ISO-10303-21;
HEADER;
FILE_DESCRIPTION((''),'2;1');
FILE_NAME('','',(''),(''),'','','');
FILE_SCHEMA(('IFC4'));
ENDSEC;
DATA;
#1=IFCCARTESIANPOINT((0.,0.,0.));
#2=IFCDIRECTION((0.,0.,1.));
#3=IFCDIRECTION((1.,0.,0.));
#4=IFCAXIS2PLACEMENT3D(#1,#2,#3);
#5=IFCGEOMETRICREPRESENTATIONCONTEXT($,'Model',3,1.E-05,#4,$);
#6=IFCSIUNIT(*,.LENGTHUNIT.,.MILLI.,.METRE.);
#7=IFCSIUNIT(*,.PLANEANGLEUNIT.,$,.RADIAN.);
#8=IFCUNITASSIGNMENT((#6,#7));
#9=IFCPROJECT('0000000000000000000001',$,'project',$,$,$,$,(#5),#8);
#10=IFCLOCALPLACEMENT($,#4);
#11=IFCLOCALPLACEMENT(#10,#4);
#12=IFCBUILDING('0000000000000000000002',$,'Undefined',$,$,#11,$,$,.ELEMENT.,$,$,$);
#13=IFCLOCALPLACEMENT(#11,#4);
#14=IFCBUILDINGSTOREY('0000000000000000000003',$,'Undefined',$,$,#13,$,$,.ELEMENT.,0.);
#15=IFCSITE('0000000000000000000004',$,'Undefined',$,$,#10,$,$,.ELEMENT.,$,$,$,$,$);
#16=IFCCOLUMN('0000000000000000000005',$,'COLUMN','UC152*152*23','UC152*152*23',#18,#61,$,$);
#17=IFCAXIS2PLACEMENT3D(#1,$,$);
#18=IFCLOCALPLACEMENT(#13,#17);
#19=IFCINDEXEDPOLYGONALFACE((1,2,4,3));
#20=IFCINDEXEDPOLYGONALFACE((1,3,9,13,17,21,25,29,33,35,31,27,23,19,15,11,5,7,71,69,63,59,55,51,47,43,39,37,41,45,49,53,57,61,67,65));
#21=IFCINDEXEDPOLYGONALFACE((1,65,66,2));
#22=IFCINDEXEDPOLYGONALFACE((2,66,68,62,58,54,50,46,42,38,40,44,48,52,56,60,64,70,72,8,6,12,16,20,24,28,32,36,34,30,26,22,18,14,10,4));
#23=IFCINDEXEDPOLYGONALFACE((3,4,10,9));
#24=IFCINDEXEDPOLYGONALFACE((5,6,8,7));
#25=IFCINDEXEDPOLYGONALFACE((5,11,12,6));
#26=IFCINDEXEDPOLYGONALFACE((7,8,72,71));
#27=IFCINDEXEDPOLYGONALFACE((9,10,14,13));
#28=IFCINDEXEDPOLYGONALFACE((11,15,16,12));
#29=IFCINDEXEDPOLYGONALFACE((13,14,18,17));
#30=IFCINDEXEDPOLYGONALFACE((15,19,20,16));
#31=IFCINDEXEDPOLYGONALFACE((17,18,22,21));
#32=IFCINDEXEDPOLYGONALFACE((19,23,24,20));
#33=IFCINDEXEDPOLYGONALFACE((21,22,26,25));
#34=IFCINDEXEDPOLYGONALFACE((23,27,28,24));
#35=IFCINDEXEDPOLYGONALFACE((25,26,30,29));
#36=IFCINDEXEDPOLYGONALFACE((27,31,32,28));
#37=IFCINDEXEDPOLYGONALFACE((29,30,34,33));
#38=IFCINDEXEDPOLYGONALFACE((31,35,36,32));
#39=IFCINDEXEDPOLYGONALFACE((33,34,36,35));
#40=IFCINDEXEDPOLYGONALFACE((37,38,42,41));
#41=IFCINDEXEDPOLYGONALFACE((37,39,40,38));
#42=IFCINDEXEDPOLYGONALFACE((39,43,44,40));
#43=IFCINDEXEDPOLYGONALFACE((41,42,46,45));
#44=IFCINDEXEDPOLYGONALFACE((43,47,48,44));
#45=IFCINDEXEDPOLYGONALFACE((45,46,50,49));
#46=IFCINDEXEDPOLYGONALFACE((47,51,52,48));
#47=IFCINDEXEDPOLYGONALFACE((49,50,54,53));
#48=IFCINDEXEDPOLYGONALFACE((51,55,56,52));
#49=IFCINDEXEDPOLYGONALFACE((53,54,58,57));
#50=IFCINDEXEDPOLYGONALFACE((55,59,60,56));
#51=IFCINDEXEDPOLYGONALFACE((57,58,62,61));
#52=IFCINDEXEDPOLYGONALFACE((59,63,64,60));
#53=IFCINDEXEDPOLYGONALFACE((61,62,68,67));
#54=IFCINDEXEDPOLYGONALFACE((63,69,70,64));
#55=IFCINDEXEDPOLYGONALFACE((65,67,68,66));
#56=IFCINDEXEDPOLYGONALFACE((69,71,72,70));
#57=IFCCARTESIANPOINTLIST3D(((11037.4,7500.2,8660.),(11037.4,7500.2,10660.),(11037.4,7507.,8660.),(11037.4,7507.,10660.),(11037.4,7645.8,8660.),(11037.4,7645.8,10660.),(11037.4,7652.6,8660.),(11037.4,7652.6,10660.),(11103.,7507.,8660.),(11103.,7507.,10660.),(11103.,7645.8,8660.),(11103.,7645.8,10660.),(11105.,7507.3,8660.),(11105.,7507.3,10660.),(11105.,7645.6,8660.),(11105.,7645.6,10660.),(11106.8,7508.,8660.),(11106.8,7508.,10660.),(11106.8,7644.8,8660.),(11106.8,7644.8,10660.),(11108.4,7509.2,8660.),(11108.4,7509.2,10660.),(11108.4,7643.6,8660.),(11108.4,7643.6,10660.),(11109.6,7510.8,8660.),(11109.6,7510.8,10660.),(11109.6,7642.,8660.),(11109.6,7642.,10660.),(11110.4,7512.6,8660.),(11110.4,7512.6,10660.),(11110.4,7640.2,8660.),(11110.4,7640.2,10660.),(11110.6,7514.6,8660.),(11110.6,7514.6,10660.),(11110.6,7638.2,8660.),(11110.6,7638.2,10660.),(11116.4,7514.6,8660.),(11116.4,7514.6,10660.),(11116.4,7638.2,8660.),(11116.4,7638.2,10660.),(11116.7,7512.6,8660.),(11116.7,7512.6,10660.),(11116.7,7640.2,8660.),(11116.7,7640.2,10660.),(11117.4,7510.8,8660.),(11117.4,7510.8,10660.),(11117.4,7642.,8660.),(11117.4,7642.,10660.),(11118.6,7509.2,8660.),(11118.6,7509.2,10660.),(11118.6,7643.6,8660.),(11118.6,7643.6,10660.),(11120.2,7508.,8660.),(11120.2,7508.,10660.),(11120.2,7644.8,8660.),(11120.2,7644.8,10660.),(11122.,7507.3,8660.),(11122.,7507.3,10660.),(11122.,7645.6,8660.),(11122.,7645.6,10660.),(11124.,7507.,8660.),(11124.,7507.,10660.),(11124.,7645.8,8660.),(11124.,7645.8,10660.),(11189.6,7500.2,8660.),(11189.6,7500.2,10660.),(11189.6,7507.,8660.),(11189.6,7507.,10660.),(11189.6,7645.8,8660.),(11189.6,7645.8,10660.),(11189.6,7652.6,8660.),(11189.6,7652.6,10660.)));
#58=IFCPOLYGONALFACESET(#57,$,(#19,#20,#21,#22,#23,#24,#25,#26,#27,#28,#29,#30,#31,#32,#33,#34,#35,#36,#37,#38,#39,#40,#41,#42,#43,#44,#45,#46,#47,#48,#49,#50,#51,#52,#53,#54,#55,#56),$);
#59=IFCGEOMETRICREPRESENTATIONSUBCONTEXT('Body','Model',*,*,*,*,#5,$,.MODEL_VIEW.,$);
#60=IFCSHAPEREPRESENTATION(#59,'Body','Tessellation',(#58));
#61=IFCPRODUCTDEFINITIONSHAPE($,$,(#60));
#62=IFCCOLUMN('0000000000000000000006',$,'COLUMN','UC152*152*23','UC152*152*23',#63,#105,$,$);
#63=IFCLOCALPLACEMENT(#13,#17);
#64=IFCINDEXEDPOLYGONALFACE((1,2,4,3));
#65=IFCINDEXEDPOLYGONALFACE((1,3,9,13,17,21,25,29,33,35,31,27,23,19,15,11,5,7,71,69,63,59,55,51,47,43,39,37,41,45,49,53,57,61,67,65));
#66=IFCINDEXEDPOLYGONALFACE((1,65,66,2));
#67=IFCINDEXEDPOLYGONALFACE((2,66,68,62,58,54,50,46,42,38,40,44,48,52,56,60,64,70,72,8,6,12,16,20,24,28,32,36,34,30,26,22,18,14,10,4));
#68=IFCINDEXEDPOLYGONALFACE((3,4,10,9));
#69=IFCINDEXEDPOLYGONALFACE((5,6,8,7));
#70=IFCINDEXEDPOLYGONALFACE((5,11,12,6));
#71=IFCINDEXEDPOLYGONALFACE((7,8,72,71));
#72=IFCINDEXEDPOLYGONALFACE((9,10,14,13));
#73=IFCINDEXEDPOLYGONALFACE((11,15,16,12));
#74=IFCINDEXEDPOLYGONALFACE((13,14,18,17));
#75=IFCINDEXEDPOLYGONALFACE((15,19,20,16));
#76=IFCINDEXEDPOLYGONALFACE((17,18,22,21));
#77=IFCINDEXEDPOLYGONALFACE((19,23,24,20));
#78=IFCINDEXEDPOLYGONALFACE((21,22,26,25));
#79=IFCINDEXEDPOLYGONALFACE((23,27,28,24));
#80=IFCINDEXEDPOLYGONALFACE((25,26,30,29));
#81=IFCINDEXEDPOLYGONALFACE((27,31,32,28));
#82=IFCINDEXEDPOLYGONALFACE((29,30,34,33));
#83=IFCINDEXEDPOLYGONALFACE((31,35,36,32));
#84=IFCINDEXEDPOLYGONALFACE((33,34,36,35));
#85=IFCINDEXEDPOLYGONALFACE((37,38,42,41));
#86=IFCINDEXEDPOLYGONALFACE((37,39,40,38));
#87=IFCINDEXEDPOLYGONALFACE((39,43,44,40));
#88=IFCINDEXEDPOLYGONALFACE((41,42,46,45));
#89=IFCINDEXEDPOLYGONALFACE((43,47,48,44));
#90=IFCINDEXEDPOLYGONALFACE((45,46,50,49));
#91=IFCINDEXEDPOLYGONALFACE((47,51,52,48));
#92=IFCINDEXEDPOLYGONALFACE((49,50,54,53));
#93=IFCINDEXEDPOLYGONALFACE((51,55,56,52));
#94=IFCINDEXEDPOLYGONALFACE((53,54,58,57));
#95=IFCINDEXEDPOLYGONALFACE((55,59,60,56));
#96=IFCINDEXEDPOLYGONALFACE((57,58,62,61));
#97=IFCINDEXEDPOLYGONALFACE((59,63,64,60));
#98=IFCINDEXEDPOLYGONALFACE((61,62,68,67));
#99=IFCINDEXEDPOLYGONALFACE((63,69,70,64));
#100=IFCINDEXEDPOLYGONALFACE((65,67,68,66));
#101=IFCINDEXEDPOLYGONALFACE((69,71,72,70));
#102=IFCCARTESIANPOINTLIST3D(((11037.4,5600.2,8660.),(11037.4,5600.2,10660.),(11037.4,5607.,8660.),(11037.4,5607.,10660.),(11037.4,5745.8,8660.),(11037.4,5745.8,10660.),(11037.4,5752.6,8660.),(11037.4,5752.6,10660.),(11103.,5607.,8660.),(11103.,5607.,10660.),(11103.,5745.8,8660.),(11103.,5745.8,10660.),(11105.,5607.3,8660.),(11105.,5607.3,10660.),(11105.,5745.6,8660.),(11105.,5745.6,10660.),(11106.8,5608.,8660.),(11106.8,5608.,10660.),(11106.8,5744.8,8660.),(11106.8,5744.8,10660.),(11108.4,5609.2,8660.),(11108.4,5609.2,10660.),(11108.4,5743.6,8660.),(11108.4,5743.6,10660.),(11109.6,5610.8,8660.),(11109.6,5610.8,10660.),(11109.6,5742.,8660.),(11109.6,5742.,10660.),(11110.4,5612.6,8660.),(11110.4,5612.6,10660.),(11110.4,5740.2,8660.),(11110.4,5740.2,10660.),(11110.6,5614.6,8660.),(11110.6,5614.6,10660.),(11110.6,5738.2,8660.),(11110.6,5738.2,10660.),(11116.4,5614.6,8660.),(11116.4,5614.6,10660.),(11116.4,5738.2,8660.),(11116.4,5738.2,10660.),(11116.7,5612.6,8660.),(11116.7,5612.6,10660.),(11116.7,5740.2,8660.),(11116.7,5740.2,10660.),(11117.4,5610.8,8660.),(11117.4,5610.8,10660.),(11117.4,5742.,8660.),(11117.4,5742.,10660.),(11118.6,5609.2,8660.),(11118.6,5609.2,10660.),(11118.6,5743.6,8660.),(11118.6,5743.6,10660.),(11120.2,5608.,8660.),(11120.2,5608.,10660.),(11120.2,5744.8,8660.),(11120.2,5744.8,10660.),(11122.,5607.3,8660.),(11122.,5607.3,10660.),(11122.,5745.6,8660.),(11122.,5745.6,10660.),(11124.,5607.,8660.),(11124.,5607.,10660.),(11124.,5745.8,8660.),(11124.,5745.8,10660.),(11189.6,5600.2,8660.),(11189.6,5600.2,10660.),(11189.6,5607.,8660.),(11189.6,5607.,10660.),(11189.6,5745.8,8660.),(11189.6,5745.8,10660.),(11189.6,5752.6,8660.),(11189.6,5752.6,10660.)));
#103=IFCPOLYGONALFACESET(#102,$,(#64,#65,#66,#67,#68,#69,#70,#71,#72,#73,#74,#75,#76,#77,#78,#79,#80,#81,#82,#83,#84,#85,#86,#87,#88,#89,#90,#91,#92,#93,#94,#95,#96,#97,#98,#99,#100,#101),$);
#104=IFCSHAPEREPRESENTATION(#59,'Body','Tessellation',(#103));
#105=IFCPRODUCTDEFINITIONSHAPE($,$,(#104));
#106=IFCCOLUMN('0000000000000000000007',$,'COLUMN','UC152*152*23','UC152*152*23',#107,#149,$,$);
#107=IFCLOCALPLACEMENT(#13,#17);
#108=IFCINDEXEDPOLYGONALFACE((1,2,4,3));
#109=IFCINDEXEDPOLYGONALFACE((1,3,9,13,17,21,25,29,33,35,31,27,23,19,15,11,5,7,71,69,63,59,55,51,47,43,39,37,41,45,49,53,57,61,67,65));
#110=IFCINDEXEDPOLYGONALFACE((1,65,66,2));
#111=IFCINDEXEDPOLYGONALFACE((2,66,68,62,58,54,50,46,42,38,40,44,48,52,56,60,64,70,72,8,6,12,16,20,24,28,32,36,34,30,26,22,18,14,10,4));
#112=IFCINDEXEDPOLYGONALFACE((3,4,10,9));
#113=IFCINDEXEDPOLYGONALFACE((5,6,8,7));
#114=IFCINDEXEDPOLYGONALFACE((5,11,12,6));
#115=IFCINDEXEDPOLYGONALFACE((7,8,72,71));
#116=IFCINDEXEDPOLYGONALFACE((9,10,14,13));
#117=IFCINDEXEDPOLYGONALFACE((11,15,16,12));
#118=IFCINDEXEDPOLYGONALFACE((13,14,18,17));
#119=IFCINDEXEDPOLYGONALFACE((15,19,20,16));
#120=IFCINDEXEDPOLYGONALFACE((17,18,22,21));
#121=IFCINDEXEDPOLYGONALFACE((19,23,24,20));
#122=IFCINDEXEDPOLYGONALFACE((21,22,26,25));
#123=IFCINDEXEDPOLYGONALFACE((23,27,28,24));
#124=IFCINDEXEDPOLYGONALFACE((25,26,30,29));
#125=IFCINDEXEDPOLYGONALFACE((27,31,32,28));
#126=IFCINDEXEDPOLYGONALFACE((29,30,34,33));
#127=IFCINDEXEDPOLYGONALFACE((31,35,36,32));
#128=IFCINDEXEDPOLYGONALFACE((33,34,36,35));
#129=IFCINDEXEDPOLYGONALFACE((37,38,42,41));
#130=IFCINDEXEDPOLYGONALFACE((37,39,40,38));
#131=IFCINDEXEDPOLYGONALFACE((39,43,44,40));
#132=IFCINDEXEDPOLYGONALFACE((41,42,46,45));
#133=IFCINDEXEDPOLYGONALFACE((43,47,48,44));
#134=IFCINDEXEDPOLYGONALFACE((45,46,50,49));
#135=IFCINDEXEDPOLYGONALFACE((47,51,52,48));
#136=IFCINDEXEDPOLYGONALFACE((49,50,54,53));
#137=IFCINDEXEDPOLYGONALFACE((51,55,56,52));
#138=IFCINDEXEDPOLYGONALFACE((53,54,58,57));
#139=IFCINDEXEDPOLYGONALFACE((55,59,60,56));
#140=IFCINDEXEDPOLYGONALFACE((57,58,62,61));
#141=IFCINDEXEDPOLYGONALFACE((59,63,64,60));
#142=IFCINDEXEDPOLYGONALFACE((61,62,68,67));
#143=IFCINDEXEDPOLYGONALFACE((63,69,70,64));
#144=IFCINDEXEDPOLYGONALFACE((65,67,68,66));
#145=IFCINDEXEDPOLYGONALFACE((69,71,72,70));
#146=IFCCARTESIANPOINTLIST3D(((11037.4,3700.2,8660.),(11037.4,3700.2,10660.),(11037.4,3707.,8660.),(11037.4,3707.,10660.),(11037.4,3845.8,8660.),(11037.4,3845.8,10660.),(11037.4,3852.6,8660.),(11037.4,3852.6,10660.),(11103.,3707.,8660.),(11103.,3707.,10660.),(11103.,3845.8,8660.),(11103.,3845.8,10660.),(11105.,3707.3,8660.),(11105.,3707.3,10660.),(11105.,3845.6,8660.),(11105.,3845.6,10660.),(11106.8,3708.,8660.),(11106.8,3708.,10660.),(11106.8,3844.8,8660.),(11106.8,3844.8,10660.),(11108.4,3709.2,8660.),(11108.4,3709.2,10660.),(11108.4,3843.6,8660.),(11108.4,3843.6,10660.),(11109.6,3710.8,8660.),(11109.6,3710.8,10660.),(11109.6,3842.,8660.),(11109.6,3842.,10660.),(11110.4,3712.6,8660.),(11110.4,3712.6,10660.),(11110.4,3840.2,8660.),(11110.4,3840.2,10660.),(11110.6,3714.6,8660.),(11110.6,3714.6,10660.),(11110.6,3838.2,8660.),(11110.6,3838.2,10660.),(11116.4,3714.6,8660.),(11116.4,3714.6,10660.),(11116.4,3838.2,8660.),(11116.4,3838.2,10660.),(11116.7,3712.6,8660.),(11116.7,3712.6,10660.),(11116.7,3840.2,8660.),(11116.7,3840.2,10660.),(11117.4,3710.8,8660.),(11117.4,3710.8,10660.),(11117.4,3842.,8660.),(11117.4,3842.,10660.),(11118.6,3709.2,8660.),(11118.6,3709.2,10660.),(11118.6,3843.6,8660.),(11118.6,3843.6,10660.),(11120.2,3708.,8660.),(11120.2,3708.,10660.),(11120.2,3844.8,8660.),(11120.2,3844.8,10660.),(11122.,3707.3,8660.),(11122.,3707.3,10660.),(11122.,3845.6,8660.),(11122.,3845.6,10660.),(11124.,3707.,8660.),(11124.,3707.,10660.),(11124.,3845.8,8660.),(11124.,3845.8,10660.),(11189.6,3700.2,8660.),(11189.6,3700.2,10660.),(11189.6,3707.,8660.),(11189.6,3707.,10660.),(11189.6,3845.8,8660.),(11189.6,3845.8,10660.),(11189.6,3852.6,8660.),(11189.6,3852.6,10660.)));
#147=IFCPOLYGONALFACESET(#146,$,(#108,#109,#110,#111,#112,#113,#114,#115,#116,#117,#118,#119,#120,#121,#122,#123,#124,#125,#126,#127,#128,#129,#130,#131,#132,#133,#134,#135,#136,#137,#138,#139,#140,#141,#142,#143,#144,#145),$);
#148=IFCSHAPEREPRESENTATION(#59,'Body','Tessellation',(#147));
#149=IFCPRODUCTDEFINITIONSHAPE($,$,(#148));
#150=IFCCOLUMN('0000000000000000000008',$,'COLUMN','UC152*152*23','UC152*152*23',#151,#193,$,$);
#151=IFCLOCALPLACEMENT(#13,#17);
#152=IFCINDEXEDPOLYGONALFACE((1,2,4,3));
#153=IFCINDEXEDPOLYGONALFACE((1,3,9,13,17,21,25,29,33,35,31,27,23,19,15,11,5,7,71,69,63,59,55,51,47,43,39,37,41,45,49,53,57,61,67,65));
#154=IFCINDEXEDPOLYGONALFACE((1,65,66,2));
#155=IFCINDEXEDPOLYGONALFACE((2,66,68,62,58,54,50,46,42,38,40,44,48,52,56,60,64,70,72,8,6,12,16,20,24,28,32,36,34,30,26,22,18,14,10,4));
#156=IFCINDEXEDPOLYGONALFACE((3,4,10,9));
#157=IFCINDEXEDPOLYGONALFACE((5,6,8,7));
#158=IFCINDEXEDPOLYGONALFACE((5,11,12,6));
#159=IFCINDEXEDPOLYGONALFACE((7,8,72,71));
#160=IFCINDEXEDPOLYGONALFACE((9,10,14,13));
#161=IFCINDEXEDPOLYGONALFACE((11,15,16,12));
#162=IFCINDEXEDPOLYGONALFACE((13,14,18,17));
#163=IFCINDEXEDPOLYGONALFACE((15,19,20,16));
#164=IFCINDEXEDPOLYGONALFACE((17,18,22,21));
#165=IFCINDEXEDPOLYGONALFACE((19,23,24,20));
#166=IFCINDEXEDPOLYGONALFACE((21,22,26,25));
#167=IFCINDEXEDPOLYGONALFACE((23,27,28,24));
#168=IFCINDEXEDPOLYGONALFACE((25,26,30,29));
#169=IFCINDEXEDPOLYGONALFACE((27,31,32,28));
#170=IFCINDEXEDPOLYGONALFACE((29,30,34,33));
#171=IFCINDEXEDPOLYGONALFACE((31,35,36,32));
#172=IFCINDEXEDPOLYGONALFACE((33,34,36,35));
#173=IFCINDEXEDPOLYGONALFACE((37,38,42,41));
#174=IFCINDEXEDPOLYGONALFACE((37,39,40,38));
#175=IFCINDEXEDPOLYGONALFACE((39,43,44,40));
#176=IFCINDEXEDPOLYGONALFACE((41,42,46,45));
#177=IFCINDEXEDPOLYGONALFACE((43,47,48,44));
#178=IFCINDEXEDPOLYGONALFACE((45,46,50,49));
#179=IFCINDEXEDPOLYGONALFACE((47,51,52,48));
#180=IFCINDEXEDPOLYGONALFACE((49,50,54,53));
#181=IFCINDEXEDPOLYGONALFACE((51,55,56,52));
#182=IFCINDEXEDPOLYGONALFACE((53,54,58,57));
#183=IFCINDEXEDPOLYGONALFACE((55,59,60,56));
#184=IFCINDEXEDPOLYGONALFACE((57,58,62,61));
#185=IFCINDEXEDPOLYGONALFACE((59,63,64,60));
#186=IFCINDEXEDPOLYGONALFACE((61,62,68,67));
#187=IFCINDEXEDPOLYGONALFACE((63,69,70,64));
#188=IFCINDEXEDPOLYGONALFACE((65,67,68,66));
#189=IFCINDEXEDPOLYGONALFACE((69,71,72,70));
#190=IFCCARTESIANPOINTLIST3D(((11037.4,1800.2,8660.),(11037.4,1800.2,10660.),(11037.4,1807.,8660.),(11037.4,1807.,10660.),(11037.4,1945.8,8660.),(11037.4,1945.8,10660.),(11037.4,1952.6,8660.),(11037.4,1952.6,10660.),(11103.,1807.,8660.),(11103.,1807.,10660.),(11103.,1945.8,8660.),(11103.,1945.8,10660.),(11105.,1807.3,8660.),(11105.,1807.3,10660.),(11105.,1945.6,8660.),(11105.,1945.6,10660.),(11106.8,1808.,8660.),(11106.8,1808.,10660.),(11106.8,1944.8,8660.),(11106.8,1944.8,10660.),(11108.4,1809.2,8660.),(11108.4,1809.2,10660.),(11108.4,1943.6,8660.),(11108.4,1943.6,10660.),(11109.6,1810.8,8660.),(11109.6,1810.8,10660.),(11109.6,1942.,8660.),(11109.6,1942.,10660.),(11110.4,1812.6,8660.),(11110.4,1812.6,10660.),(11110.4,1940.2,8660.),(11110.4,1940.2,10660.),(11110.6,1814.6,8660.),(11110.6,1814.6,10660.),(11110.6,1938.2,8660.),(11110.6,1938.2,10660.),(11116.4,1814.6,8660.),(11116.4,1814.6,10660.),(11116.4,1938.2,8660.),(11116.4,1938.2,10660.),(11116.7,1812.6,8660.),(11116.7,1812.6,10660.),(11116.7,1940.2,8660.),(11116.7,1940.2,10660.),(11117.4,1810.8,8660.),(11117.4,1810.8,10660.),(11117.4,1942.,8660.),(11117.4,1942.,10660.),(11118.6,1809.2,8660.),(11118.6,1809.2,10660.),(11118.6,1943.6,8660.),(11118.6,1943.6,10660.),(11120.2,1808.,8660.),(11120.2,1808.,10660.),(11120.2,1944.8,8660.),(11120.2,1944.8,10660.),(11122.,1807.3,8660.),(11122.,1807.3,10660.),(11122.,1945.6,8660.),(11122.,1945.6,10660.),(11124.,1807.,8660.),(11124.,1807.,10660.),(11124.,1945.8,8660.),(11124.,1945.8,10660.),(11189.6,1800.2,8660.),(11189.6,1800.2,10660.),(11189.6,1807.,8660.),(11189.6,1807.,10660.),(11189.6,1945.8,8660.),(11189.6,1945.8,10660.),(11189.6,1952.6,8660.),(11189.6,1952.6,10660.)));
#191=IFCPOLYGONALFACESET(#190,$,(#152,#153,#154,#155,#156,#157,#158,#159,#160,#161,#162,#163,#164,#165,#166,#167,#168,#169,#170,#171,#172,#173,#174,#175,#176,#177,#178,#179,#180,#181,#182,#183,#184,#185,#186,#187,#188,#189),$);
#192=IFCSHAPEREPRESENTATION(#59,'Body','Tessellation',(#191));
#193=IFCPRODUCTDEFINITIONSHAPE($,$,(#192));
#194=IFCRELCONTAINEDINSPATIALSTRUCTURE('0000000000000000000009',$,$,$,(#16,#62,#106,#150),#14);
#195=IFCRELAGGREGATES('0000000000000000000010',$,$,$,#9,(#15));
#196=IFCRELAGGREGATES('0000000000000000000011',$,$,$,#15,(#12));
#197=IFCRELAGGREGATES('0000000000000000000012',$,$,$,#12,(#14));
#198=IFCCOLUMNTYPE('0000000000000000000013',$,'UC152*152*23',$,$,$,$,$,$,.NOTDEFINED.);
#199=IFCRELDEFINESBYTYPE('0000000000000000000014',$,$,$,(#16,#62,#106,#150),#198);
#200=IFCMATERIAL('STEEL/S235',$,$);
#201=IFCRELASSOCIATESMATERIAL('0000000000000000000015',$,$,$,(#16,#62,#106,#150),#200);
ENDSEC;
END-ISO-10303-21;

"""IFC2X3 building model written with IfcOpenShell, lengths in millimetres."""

from ifc_helpers import new_model, si_unit, frame, origin_with_axes, origin_2d_with_axis, place, context, subcontext, project, spatial, i_section, extrude, material, type_object, element, save


model = new_model("IFC2X3")

# Units and contexts
model_context = context("Model", 3, precision=1e-05, world=origin_with_axes())
body_context = subcontext(model_context, "Body", "Model", "MODEL_VIEW")
ifc_project = project(units=[si_unit("LENGTHUNIT", "METRE", prefix="MILLI"), si_unit("PLANEANGLEUNIT", "RADIAN")], contexts=[model_context])

# Site, building, storey
site_placement = place(None, origin_with_axes())
site = spatial("IfcSite", under=ifc_project, at=site_placement, Name="Undefined", CompositionType="ELEMENT")
building_placement = place(site_placement, origin_with_axes())
building = spatial("IfcBuilding", under=site, at=building_placement, Name="Undefined", CompositionType="ELEMENT")
storey_placement = place(building_placement, origin_with_axes())
storey = spatial("IfcBuildingStorey", under=building, at=storey_placement, Name="Undefined", CompositionType="ELEMENT", Elevation=0.0)

# Columns
ifc_material = material(Name="STEEL/S235")
column_type = type_object("IfcColumnType", Name="UC152*152*23", PredefinedType="NOTDEFINED")
for number, where, z_axis, x_axis, name in (
    (1, (11113.5, 7576.4, 8660.0), (0.0, 0.0, 1.0), (0.0, -1.0, 0.0), "COLUMN"),
    (2, (11113.5, 5676.4, 8660.0), (0.0, 0.0, 1.0), (0.0, -1.0, 0.0), "COLUMN"),
    (3, (11113.5, 3776.4, 8660.0), (0.0, 0.0, 1.0), (0.0, -1.0, 0.0), "COLUMN"),
    (4, (11113.5, 1876.4, 8660.0), (0.0, 0.0, 1.0), (0.0, -1.0, 0.0), "COLUMN"),
):
    element("IfcColumn", number, at=place(storey_placement, frame(where, z_axis=z_axis, x_axis=x_axis)), inside=storey, type_object=column_type, material=ifc_material, Name=name, Description="UC152*152*23", ObjectType="UC152*152*23", context=body_context, shape_type="SweptSolid", body=[
        extrude(i_section(OverallWidth=152.2, OverallDepth=152.4, WebThickness=5.8, FlangeThickness=6.8, FilletRadius=7.6, at=origin_2d_with_axis()), frame((0.0, 0.0, 2000.0), z_axis=(0.0, 0.0, -1.0), x_axis=(0.0, 1.0, 0.0)), (0.0, 0.0, 1.0), 2000.0),
    ])

save(model, "model.ifc")
